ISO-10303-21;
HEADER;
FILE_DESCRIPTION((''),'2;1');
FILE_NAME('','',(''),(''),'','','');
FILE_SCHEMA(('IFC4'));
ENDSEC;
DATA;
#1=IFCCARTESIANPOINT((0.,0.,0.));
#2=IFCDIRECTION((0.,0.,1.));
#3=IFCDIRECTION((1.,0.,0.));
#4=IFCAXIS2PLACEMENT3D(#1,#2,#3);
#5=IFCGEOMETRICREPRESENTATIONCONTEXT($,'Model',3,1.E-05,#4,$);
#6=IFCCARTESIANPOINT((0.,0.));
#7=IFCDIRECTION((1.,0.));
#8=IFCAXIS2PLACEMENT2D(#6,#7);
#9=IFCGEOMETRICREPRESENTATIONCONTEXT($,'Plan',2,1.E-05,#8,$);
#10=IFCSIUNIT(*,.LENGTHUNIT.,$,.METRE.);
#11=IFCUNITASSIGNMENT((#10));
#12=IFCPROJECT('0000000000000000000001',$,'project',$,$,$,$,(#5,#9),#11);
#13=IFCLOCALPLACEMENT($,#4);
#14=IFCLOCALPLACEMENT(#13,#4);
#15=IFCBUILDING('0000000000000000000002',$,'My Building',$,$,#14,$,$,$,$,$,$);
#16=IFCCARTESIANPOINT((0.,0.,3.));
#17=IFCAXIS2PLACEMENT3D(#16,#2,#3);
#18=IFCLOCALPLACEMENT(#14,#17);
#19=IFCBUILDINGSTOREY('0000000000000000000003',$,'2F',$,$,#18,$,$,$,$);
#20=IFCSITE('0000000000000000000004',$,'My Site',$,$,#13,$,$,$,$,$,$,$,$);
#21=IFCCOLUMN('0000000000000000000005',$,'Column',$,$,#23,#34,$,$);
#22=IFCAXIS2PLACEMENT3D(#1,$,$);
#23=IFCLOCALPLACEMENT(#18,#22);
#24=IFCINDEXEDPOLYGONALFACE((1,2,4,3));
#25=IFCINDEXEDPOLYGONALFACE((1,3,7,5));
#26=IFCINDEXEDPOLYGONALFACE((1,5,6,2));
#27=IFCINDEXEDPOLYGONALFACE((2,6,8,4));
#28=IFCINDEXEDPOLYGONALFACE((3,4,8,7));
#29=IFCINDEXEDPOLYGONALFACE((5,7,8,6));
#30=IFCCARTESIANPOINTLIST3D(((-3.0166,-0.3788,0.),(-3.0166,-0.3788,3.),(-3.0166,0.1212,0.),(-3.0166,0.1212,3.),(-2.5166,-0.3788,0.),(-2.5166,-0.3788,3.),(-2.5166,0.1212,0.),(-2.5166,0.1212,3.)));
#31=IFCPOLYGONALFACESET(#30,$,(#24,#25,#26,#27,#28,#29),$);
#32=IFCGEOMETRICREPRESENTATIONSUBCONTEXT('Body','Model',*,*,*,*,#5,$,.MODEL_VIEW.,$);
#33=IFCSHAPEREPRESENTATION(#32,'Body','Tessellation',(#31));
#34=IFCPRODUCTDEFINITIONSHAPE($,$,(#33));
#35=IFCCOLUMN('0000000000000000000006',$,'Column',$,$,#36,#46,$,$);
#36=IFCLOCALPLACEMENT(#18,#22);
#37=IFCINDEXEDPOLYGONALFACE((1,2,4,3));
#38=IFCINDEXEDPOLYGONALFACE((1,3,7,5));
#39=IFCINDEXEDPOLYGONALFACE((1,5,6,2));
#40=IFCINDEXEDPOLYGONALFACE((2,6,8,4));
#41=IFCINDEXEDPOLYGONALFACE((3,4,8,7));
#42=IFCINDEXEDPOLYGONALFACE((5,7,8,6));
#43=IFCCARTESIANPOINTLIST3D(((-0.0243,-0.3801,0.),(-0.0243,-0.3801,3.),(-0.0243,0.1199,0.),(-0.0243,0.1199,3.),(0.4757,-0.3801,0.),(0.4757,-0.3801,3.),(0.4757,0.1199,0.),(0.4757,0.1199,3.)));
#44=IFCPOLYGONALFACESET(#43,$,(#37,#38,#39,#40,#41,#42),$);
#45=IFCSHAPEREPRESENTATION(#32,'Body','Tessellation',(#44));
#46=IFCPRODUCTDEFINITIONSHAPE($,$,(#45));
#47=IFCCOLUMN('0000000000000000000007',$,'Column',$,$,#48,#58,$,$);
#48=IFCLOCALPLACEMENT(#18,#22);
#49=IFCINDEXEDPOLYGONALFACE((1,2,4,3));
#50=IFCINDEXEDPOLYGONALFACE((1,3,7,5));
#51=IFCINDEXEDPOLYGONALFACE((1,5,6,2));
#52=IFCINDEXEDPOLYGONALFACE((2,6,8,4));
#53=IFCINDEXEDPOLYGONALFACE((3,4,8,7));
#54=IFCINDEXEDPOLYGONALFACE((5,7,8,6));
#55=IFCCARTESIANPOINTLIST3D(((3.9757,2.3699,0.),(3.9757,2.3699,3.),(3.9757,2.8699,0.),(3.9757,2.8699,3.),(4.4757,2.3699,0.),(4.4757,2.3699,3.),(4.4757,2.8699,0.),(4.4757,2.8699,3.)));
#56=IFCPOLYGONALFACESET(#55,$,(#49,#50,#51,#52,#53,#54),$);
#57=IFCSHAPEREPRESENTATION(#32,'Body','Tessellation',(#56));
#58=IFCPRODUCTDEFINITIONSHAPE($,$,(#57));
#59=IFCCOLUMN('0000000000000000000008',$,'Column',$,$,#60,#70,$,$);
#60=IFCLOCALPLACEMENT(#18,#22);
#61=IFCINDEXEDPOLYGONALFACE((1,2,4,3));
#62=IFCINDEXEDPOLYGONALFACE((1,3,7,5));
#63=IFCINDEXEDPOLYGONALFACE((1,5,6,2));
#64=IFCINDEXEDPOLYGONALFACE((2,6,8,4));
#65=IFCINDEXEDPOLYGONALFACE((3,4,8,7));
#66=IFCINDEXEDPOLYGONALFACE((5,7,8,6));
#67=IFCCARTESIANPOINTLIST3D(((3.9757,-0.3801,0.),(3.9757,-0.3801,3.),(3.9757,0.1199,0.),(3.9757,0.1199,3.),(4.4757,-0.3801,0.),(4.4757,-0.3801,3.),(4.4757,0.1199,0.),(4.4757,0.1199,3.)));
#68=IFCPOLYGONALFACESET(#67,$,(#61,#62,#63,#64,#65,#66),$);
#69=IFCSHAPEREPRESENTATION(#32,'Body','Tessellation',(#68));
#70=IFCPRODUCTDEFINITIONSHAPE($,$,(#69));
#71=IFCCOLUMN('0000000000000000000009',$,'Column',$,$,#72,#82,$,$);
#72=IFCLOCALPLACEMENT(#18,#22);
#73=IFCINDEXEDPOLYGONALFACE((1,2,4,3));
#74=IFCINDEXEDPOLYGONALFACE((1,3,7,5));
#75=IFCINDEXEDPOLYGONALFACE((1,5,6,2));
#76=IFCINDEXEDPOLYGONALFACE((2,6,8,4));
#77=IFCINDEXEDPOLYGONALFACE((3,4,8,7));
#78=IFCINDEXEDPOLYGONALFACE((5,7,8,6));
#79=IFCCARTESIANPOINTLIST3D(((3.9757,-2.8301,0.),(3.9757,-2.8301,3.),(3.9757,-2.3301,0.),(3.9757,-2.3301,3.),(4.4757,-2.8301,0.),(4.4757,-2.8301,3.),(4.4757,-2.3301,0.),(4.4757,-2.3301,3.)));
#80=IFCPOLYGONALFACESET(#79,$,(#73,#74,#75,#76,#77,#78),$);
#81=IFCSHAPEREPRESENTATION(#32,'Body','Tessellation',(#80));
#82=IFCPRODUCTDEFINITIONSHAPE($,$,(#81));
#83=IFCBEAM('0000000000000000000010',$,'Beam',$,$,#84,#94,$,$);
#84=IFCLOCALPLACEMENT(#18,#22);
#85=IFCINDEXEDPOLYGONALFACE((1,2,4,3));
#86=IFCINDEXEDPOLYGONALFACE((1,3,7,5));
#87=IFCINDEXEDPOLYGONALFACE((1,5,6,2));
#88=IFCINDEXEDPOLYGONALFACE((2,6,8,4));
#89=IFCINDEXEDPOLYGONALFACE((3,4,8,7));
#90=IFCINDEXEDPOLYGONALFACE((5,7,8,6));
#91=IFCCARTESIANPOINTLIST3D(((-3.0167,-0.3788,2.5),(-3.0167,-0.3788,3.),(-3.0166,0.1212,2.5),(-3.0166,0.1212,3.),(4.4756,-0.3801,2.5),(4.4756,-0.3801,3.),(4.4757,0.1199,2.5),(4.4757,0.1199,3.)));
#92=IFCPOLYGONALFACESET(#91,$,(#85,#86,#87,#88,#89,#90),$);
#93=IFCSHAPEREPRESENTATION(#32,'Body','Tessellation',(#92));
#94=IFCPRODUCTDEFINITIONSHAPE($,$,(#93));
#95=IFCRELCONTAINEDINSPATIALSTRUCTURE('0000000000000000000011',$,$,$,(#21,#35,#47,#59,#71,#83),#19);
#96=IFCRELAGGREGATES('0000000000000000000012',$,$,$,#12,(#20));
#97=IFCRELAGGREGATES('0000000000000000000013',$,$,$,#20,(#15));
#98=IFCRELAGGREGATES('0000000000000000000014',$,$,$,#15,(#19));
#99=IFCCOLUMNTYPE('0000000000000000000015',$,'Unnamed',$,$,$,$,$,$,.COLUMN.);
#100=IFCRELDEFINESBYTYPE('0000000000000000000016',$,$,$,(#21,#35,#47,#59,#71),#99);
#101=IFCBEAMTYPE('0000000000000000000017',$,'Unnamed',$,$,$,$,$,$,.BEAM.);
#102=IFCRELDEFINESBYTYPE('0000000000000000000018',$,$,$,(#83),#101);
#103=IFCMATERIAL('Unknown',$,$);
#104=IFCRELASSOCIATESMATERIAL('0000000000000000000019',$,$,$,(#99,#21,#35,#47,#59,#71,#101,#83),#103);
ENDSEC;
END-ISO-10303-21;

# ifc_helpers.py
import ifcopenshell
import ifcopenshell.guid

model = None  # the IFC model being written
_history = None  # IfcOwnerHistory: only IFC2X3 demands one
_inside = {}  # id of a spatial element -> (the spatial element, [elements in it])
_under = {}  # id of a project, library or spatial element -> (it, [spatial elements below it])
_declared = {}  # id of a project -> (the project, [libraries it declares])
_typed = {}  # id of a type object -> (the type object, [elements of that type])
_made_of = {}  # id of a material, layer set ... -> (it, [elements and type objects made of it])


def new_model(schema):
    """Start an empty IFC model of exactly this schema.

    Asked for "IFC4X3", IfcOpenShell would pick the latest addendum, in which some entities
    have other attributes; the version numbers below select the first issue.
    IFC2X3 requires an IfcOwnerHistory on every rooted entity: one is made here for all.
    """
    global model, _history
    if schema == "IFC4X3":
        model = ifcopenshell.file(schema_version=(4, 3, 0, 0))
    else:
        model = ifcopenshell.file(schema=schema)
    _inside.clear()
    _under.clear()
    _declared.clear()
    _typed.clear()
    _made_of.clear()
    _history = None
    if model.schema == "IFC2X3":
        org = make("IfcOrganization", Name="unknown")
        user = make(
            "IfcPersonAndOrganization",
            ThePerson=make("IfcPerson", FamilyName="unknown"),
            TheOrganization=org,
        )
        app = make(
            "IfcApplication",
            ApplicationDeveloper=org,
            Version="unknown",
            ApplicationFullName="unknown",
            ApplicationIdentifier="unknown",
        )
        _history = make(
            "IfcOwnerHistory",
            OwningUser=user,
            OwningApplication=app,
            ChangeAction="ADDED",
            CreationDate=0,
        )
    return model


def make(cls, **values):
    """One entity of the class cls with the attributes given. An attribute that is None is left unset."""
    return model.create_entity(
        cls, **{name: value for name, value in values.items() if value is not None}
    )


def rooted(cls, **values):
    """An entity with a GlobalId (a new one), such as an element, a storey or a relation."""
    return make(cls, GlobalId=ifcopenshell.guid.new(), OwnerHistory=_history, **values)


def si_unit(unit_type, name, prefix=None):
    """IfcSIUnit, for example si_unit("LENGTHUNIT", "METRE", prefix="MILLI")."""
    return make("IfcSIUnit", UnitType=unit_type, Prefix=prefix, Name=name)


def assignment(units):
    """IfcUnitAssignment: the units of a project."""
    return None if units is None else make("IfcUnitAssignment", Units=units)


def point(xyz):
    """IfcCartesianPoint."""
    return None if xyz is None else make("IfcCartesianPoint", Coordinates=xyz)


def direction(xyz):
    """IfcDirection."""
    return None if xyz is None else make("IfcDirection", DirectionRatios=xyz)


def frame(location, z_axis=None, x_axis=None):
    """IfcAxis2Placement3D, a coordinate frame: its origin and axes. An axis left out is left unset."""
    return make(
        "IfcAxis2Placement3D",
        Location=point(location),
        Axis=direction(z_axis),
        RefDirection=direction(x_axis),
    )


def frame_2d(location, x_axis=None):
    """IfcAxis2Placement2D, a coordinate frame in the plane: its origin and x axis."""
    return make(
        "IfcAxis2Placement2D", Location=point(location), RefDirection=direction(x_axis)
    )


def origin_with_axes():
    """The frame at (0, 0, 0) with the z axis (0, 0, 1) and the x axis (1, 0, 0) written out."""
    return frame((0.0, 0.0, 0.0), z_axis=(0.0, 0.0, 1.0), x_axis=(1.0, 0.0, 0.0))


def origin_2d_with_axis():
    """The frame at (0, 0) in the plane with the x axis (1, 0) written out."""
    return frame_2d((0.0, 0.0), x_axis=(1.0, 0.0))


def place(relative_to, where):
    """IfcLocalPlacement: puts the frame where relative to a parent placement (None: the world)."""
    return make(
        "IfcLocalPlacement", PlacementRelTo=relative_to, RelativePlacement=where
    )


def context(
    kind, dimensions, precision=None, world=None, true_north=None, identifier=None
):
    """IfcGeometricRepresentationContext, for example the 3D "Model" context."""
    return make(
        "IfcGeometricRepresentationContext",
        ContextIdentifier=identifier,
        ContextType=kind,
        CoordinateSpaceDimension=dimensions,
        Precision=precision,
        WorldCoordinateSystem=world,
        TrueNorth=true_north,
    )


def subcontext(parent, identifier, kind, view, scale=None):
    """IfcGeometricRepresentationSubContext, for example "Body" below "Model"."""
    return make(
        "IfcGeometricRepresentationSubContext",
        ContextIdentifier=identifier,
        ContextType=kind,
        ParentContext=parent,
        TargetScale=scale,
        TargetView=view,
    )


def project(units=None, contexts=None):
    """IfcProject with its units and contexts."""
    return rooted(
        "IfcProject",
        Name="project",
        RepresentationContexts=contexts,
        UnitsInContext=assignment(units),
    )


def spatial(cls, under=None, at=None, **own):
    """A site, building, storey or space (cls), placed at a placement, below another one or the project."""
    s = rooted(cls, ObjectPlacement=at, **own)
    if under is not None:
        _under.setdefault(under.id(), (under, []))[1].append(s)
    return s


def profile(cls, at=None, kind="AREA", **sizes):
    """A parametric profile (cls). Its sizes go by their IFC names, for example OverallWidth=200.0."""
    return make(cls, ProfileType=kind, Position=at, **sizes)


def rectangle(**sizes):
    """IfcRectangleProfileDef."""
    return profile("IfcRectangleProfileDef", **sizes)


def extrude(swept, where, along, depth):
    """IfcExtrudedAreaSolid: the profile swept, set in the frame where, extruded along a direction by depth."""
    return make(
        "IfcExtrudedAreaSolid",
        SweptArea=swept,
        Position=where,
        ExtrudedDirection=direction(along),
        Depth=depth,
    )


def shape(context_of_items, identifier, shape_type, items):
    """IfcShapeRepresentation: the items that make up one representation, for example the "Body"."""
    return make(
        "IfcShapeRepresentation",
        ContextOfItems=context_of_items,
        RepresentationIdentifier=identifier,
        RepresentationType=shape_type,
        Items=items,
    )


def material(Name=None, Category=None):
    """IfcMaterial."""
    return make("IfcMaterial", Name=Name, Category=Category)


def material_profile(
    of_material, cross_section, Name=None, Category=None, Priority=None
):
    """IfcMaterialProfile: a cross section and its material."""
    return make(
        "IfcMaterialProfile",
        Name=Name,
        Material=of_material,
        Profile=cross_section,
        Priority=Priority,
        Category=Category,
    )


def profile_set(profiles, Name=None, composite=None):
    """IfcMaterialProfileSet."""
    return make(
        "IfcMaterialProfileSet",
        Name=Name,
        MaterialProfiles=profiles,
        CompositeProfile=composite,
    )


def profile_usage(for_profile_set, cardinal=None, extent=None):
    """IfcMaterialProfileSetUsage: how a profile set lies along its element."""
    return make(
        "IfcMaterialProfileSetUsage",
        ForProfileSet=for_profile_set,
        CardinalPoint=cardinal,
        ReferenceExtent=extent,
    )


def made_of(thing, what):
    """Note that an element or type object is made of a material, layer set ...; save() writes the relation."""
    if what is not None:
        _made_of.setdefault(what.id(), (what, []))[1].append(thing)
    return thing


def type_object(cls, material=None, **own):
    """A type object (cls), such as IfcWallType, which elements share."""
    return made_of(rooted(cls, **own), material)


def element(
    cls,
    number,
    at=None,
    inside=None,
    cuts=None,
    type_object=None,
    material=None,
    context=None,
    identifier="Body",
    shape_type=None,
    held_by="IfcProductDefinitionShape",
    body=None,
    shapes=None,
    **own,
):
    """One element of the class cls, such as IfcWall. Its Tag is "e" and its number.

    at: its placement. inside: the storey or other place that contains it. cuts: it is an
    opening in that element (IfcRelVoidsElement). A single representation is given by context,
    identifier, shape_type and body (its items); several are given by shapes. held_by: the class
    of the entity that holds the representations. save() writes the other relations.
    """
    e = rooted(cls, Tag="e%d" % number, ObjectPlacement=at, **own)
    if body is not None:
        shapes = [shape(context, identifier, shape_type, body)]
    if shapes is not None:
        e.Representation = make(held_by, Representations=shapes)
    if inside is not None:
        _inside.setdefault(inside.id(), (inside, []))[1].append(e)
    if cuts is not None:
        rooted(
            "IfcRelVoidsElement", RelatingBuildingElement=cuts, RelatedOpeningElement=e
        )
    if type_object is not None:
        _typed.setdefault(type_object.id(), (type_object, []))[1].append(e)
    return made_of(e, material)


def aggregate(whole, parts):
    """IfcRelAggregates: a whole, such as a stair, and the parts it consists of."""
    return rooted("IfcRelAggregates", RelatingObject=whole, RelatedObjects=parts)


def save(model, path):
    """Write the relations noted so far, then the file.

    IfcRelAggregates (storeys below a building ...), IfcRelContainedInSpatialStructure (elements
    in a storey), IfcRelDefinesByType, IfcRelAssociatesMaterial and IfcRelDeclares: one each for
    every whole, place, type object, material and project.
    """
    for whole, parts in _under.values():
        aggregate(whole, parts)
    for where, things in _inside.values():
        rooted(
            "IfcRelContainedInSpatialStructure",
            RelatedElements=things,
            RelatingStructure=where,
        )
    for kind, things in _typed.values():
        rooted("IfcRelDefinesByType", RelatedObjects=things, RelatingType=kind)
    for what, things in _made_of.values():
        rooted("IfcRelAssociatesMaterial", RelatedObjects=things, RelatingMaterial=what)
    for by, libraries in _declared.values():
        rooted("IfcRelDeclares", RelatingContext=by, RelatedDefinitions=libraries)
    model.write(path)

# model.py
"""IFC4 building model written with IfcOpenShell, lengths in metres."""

from ifc_helpers import new_model, si_unit, frame, origin_with_axes, origin_2d_with_axis, place, context, subcontext, project, spatial, rectangle, extrude, material, material_profile, profile_set, profile_usage, type_object, element, save


model = new_model("IFC4")

# Units and contexts
model_context = context("Model", 3, precision=1e-05, world=origin_with_axes())
plan_context = context("Plan", 2, precision=1e-05, world=origin_2d_with_axis())
body_context_1 = subcontext(model_context, "Body", "Model", "MODEL_VIEW")
ifc_project = project(units=[si_unit("LENGTHUNIT", "METRE")], contexts=[model_context, plan_context])

# Site, building, storey
site_placement = place(None, origin_with_axes())
site = spatial("IfcSite", under=ifc_project, at=site_placement, Name="My Site")
building_placement = place(site_placement, origin_with_axes())
building = spatial("IfcBuilding", under=site, at=building_placement, Name="My Building")
storey_placement = place(building_placement, frame((0.0, 0.0, 3.0), z_axis=(0.0, 0.0, 1.0), x_axis=(1.0, 0.0, 0.0)))
storey = spatial("IfcBuildingStorey", under=building, at=storey_placement, Name="2F")

# Columns
ifc_material = material(Name="Unknown")
ifc_material_profile_1 = material_profile(ifc_material, rectangle(XDim=0.5, YDim=0.5))
ifc_profile_set_1 = profile_set([ifc_material_profile_1])
ifc_profile_usage_1 = profile_usage(ifc_profile_set_1, cardinal=5)
column_type = type_object("IfcColumnType", Name="Unnamed", PredefinedType="COLUMN", material=ifc_profile_set_1)
column_1_placement = place(storey_placement, frame((-2.7666, -0.1288, 0.0), z_axis=(0.0, 0.0, 1.0), x_axis=(1.0, 0.0, 0.0)))
element("IfcColumn", 1, at=column_1_placement, inside=storey, type_object=column_type, material=ifc_profile_usage_1, Name="Column", context=body_context_1, shape_type="SweptSolid", body=[
    extrude(rectangle(XDim=0.5, YDim=0.5), origin_with_axes(), (0.0, 0.0, 1.0), 3.0),
])
ifc_profile_usage_2 = profile_usage(ifc_profile_set_1, cardinal=5)
column_2_placement = place(storey_placement, frame((0.2257, -0.1301, 0.0), z_axis=(0.0, 0.0, 1.0), x_axis=(1.0, 0.0, 0.0)))
element("IfcColumn", 2, at=column_2_placement, inside=storey, type_object=column_type, material=ifc_profile_usage_2, Name="Column", context=body_context_1, shape_type="SweptSolid", body=[
    extrude(rectangle(XDim=0.5, YDim=0.5), origin_with_axes(), (0.0, 0.0, 1.0), 3.0),
])
ifc_profile_usage_3 = profile_usage(ifc_profile_set_1, cardinal=5)
column_3_placement = place(storey_placement, frame((4.2257, 2.6199, 0.0), z_axis=(0.0, 0.0, 1.0), x_axis=(1.0, 0.0, 0.0)))
element("IfcColumn", 3, at=column_3_placement, inside=storey, type_object=column_type, material=ifc_profile_usage_3, Name="Column", context=body_context_1, shape_type="SweptSolid", body=[
    extrude(rectangle(XDim=0.5, YDim=0.5), origin_with_axes(), (0.0, 0.0, 1.0), 3.0),
])
ifc_profile_usage_4 = profile_usage(ifc_profile_set_1, cardinal=5)
column_4_placement = place(storey_placement, frame((4.2257, -0.1301, 0.0), z_axis=(0.0, 0.0, 1.0), x_axis=(1.0, 0.0, 0.0)))
element("IfcColumn", 4, at=column_4_placement, inside=storey, type_object=column_type, material=ifc_profile_usage_4, Name="Column", context=body_context_1, shape_type="SweptSolid", body=[
    extrude(rectangle(XDim=0.5, YDim=0.5), origin_with_axes(), (0.0, 0.0, 1.0), 3.0),
])
ifc_profile_usage_5 = profile_usage(ifc_profile_set_1, cardinal=5)
column_5_placement = place(storey_placement, frame((4.2257, -2.5801, 0.0), z_axis=(0.0, 0.0, 1.0), x_axis=(1.0, 0.0, 0.0)))
element("IfcColumn", 5, at=column_5_placement, inside=storey, type_object=column_type, material=ifc_profile_usage_5, Name="Column", context=body_context_1, shape_type="SweptSolid", body=[
    extrude(rectangle(XDim=0.5, YDim=0.5), origin_with_axes(), (0.0, 0.0, 1.0), 3.0),
])

# Beam
ifc_material_profile_2 = material_profile(ifc_material, rectangle(XDim=0.5, YDim=0.5))
ifc_profile_set_2 = profile_set([ifc_material_profile_2])
ifc_profile_usage_6 = profile_usage(ifc_profile_set_2, cardinal=7)
beam_type = type_object("IfcBeamType", Name="Unnamed", PredefinedType="BEAM", material=ifc_profile_set_2)
beam_placement = place(storey_placement, frame((-3.0166, 0.1212, 3.0), z_axis=(1.0, -0.000175, 0.0), x_axis=(0.000175, 1.0, 0.0)))
element("IfcBeam", 6, at=beam_placement, inside=storey, type_object=beam_type, material=ifc_profile_usage_6, Name="Beam", context=body_context_1, shape_type="SweptSolid", body=[
    extrude(rectangle(XDim=0.5, YDim=0.5), frame((-0.25, -0.25, 0.0), z_axis=(0.0, 0.0, 1.0), x_axis=(1.0, 0.0, 0.0)), (0.0, 0.0, 1.0), 7.4924),
])

save(model, "model.ifc")
